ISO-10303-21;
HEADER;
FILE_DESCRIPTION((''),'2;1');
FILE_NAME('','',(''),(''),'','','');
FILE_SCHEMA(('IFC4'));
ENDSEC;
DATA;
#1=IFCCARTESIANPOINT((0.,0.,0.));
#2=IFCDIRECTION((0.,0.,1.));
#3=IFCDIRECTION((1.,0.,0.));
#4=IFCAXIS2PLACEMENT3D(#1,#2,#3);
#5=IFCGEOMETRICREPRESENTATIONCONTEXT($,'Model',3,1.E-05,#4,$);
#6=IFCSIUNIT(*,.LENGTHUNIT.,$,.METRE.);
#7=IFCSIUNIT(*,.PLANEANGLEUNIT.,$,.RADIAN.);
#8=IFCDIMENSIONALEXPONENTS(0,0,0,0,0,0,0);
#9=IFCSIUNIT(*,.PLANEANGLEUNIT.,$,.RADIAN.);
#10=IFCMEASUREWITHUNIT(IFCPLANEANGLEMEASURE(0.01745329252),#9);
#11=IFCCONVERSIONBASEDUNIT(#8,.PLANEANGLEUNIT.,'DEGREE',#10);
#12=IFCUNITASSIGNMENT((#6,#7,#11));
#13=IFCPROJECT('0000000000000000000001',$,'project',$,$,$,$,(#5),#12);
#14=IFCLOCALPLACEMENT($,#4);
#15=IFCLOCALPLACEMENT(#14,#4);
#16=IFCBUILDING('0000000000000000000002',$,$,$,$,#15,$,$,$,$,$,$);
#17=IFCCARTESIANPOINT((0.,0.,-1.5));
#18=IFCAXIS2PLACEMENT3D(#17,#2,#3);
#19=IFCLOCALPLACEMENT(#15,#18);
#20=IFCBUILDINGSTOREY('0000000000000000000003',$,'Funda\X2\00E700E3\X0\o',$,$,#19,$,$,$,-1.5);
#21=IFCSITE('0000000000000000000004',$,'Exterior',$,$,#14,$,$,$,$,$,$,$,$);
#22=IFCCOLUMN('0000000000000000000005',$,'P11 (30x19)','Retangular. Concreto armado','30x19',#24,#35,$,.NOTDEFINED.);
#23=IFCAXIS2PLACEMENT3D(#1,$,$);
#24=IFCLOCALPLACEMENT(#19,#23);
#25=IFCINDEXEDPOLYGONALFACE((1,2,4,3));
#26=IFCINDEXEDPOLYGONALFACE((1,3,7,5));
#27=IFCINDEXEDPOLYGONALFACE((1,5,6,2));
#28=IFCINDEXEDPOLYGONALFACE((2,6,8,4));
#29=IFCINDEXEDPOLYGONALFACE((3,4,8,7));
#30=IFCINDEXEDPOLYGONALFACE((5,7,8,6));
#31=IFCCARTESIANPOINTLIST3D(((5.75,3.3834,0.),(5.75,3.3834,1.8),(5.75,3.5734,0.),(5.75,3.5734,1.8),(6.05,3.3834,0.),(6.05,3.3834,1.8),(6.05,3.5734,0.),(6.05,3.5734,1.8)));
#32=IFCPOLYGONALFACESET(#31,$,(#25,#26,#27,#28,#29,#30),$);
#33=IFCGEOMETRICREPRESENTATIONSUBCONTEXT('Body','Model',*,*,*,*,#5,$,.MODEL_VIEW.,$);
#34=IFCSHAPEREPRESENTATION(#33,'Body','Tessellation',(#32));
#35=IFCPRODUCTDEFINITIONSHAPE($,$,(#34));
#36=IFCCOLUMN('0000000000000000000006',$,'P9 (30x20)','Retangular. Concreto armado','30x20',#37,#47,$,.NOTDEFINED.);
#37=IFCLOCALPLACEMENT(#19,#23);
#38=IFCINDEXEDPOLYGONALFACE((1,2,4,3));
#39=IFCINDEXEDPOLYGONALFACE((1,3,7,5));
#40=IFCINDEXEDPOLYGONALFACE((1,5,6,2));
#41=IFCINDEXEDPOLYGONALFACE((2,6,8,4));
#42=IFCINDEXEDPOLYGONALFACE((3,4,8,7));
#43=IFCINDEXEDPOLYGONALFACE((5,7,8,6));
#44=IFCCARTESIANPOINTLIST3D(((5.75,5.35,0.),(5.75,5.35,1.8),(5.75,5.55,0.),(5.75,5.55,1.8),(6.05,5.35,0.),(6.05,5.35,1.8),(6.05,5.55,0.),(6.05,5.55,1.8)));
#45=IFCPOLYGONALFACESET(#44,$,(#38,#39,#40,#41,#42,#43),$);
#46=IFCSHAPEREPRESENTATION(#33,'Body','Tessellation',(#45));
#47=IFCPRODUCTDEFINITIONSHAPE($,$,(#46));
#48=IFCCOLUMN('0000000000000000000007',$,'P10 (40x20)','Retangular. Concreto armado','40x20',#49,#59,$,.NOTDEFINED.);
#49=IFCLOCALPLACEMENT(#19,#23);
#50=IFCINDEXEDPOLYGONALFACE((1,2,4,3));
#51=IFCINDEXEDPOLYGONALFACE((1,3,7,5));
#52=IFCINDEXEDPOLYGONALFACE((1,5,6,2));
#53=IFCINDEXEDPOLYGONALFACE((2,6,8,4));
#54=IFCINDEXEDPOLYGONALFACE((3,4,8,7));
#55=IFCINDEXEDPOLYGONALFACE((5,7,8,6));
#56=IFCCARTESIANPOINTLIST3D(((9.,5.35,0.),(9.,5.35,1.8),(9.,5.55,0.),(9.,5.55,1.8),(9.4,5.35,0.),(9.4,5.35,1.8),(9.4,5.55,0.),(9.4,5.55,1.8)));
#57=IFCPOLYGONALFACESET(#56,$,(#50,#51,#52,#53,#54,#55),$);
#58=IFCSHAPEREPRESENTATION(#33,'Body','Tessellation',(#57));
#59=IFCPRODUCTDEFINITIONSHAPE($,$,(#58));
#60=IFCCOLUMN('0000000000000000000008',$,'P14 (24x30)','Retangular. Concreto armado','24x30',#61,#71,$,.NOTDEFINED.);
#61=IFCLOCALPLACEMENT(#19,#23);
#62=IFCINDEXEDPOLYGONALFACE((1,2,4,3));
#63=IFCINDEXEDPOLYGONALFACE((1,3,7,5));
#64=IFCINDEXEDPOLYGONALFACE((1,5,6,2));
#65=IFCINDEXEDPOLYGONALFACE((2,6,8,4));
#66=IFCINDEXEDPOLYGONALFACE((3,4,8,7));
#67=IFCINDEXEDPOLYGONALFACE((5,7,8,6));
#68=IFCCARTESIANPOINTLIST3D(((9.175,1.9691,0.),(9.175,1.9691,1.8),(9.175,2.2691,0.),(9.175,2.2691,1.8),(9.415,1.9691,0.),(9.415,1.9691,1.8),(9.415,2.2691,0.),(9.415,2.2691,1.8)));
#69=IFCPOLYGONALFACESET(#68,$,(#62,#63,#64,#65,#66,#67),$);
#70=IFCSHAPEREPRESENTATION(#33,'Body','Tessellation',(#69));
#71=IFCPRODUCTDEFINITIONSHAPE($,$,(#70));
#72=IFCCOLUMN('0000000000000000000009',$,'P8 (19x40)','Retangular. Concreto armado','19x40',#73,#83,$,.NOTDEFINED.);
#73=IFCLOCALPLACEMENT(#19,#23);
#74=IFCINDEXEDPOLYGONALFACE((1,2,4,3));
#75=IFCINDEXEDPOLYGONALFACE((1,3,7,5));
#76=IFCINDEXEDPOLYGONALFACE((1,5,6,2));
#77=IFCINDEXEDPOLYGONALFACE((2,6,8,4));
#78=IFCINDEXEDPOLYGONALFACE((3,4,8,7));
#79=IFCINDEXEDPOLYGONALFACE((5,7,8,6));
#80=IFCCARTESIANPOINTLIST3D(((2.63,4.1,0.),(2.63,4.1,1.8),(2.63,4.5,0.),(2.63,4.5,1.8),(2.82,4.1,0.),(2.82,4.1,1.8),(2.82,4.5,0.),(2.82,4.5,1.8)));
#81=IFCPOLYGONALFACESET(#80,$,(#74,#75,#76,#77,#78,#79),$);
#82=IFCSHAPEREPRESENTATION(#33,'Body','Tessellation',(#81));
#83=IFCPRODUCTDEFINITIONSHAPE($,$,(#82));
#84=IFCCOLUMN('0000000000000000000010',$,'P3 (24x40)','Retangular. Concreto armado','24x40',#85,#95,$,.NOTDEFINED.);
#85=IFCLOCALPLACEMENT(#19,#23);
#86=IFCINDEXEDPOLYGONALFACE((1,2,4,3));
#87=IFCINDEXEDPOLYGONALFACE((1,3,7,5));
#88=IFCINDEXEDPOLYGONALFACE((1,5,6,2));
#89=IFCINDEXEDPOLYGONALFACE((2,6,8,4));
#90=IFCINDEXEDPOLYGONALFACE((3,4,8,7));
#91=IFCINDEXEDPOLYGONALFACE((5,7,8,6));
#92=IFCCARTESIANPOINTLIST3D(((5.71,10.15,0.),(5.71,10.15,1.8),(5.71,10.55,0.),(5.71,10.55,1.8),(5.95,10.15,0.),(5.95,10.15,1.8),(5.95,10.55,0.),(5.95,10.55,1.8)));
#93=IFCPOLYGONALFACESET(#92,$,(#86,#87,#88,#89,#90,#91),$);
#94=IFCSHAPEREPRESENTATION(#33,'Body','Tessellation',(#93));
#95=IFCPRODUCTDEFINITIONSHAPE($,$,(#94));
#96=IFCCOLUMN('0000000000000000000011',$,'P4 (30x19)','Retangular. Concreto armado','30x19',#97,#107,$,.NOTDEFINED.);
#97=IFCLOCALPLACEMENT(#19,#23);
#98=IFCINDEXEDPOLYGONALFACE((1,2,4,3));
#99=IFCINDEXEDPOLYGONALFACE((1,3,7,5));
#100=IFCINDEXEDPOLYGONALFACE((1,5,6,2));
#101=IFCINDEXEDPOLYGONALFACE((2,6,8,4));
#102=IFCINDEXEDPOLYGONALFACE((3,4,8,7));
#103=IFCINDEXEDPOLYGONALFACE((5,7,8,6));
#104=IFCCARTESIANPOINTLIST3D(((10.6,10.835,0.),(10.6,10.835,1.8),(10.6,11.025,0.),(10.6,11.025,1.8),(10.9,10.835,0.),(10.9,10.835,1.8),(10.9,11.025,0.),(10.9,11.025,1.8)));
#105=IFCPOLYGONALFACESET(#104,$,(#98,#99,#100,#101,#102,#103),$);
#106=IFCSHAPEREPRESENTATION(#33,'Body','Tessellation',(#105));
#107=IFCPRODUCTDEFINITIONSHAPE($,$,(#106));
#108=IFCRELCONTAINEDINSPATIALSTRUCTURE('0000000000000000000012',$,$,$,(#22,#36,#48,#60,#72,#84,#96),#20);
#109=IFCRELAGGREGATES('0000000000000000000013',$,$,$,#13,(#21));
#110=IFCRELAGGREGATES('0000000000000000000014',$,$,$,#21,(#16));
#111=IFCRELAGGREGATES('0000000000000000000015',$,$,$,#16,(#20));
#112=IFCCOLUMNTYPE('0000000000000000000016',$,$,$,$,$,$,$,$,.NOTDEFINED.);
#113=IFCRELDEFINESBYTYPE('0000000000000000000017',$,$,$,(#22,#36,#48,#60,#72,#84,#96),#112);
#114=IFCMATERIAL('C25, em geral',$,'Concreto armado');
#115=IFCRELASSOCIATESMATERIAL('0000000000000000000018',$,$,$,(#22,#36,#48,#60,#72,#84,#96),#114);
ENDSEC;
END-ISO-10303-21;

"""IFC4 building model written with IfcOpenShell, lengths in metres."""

from ifc_helpers import new_model, entity, si_unit, converted_unit, frame, frame_2d, origin_with_axes, origin_2d_with_axis, place, context, subcontext, project, spatial, rectangle, extrude, material, type_object, element, save


model = new_model("IFC4")

# Units and contexts
model_context = context("Model", 3, precision=1e-05, world=origin_with_axes())
body_context = subcontext(model_context, "Body", "Model", "MODEL_VIEW")
ifc_project = project(units=[si_unit("LENGTHUNIT", "METRE"), si_unit("PLANEANGLEUNIT", "RADIAN"), converted_unit("PLANEANGLEUNIT", "DEGREE", entity("IfcPlaneAngleMeasure", 0.01745329252), si_unit("PLANEANGLEUNIT", "RADIAN"), dimensions=[0, 0, 0, 0, 0, 0, 0])], contexts=[model_context])

# Site, building, storey
site_placement = place(None, origin_with_axes())
site = spatial("IfcSite", under=ifc_project, at=site_placement, Name="Exterior")
building_placement = place(site_placement, origin_with_axes())
building = spatial("IfcBuilding", under=site, at=building_placement)
storey_placement = place(building_placement, frame((0.0, 0.0, -1.5), z_axis=(0.0, 0.0, 1.0), x_axis=(1.0, 0.0, 0.0)))
storey = spatial("IfcBuildingStorey", under=building, at=storey_placement, Name="Fundação", Elevation=-1.5)

# Shared definitions
ifc_material_1 = material(Name="C25, em geral", Category="Concreto armado")

# Columns
column_type = type_object("IfcColumnType", PredefinedType="NOTDEFINED")
column_1_placement = place(storey_placement, frame((5.9, 3.4784, 0.0), z_axis=(0.0, 0.0, 1.0), x_axis=(1.0, 0.0, 0.0)))
element("IfcColumn", 1, at=column_1_placement, inside=storey, type_object=column_type, material=ifc_material_1, Name="P11 (30x19)", Description="Retangular. Concreto armado", ObjectType="30x19", PredefinedType="NOTDEFINED", context=body_context, shape_type="SweptSolid", body=[
    extrude(rectangle(XDim=0.3, YDim=0.19, at=origin_2d_with_axis()), origin_with_axes(), (0.0, 0.0, 1.0), 1.8),
])
column_2_placement = place(storey_placement, frame((5.9, 5.45, 0.0), z_axis=(0.0, 0.0, 1.0), x_axis=(1.0, 0.0, 0.0)))
element("IfcColumn", 2, at=column_2_placement, inside=storey, type_object=column_type, material=ifc_material_1, Name="P9 (30x20)", Description="Retangular. Concreto armado", ObjectType="30x20", PredefinedType="NOTDEFINED", context=body_context, shape_type="SweptSolid", body=[
    extrude(rectangle(XDim=0.3, YDim=0.2, at=origin_2d_with_axis()), origin_with_axes(), (0.0, 0.0, 1.0), 1.8),
])
column_3_placement = place(storey_placement, frame((9.2, 5.45, 0.0), z_axis=(0.0, 0.0, 1.0), x_axis=(1.0, 0.0, 0.0)))
element("IfcColumn", 3, at=column_3_placement, inside=storey, type_object=column_type, material=ifc_material_1, Name="P10 (40x20)", Description="Retangular. Concreto armado", ObjectType="40x20", PredefinedType="NOTDEFINED", context=body_context, shape_type="SweptSolid", body=[
    extrude(rectangle(XDim=0.4, YDim=0.2, at=origin_2d_with_axis()), origin_with_axes(), (0.0, 0.0, 1.0), 1.8),
])
column_4_placement = place(storey_placement, frame((9.295, 2.1191, 0.0), z_axis=(0.0, 0.0, 1.0), x_axis=(1.0, 0.0, 0.0)))
element("IfcColumn", 4, at=column_4_placement, inside=storey, type_object=column_type, material=ifc_material_1, Name="P14 (24x30)", Description="Retangular. Concreto armado", ObjectType="24x30", PredefinedType="NOTDEFINED", context=body_context, shape_type="SweptSolid", body=[
    extrude(rectangle(XDim=0.24, YDim=0.3, at=origin_2d_with_axis()), origin_with_axes(), (0.0, 0.0, 1.0), 1.8),
])
column_5_placement = place(storey_placement, frame((2.725, 4.5, 0.0), z_axis=(0.0, 0.0, 1.0), x_axis=(1.0, 0.0, 0.0)))
element("IfcColumn", 5, at=column_5_placement, inside=storey, type_object=column_type, material=ifc_material_1, Name="P8 (19x40)", Description="Retangular. Concreto armado", ObjectType="19x40", PredefinedType="NOTDEFINED", context=body_context, shape_type="SweptSolid", body=[
    extrude(rectangle(XDim=0.19, YDim=0.4, at=frame_2d((0.0, -0.2), x_axis=(1.0, 0.0))), origin_with_axes(), (0.0, 0.0, 1.0), 1.8),
])
column_6_placement = place(storey_placement, frame((5.83, 10.35, 0.0), z_axis=(0.0, 0.0, 1.0), x_axis=(1.0, 0.0, 0.0)))
element("IfcColumn", 6, at=column_6_placement, inside=storey, type_object=column_type, material=ifc_material_1, Name="P3 (24x40)", Description="Retangular. Concreto armado", ObjectType="24x40", PredefinedType="NOTDEFINED", context=body_context, shape_type="SweptSolid", body=[
    extrude(rectangle(XDim=0.24, YDim=0.4, at=origin_2d_with_axis()), origin_with_axes(), (0.0, 0.0, 1.0), 1.8),
])
column_7_placement = place(storey_placement, frame((10.75, 10.93, 0.0), z_axis=(0.0, 0.0, 1.0), x_axis=(1.0, 0.0, 0.0)))
element("IfcColumn", 7, at=column_7_placement, inside=storey, type_object=column_type, material=ifc_material_1, Name="P4 (30x19)", Description="Retangular. Concreto armado", ObjectType="30x19", PredefinedType="NOTDEFINED", context=body_context, shape_type="SweptSolid", body=[
    extrude(rectangle(XDim=0.3, YDim=0.19, at=origin_2d_with_axis()), origin_with_axes(), (0.0, 0.0, 1.0), 1.8),
])

save(model, "model.ifc")
